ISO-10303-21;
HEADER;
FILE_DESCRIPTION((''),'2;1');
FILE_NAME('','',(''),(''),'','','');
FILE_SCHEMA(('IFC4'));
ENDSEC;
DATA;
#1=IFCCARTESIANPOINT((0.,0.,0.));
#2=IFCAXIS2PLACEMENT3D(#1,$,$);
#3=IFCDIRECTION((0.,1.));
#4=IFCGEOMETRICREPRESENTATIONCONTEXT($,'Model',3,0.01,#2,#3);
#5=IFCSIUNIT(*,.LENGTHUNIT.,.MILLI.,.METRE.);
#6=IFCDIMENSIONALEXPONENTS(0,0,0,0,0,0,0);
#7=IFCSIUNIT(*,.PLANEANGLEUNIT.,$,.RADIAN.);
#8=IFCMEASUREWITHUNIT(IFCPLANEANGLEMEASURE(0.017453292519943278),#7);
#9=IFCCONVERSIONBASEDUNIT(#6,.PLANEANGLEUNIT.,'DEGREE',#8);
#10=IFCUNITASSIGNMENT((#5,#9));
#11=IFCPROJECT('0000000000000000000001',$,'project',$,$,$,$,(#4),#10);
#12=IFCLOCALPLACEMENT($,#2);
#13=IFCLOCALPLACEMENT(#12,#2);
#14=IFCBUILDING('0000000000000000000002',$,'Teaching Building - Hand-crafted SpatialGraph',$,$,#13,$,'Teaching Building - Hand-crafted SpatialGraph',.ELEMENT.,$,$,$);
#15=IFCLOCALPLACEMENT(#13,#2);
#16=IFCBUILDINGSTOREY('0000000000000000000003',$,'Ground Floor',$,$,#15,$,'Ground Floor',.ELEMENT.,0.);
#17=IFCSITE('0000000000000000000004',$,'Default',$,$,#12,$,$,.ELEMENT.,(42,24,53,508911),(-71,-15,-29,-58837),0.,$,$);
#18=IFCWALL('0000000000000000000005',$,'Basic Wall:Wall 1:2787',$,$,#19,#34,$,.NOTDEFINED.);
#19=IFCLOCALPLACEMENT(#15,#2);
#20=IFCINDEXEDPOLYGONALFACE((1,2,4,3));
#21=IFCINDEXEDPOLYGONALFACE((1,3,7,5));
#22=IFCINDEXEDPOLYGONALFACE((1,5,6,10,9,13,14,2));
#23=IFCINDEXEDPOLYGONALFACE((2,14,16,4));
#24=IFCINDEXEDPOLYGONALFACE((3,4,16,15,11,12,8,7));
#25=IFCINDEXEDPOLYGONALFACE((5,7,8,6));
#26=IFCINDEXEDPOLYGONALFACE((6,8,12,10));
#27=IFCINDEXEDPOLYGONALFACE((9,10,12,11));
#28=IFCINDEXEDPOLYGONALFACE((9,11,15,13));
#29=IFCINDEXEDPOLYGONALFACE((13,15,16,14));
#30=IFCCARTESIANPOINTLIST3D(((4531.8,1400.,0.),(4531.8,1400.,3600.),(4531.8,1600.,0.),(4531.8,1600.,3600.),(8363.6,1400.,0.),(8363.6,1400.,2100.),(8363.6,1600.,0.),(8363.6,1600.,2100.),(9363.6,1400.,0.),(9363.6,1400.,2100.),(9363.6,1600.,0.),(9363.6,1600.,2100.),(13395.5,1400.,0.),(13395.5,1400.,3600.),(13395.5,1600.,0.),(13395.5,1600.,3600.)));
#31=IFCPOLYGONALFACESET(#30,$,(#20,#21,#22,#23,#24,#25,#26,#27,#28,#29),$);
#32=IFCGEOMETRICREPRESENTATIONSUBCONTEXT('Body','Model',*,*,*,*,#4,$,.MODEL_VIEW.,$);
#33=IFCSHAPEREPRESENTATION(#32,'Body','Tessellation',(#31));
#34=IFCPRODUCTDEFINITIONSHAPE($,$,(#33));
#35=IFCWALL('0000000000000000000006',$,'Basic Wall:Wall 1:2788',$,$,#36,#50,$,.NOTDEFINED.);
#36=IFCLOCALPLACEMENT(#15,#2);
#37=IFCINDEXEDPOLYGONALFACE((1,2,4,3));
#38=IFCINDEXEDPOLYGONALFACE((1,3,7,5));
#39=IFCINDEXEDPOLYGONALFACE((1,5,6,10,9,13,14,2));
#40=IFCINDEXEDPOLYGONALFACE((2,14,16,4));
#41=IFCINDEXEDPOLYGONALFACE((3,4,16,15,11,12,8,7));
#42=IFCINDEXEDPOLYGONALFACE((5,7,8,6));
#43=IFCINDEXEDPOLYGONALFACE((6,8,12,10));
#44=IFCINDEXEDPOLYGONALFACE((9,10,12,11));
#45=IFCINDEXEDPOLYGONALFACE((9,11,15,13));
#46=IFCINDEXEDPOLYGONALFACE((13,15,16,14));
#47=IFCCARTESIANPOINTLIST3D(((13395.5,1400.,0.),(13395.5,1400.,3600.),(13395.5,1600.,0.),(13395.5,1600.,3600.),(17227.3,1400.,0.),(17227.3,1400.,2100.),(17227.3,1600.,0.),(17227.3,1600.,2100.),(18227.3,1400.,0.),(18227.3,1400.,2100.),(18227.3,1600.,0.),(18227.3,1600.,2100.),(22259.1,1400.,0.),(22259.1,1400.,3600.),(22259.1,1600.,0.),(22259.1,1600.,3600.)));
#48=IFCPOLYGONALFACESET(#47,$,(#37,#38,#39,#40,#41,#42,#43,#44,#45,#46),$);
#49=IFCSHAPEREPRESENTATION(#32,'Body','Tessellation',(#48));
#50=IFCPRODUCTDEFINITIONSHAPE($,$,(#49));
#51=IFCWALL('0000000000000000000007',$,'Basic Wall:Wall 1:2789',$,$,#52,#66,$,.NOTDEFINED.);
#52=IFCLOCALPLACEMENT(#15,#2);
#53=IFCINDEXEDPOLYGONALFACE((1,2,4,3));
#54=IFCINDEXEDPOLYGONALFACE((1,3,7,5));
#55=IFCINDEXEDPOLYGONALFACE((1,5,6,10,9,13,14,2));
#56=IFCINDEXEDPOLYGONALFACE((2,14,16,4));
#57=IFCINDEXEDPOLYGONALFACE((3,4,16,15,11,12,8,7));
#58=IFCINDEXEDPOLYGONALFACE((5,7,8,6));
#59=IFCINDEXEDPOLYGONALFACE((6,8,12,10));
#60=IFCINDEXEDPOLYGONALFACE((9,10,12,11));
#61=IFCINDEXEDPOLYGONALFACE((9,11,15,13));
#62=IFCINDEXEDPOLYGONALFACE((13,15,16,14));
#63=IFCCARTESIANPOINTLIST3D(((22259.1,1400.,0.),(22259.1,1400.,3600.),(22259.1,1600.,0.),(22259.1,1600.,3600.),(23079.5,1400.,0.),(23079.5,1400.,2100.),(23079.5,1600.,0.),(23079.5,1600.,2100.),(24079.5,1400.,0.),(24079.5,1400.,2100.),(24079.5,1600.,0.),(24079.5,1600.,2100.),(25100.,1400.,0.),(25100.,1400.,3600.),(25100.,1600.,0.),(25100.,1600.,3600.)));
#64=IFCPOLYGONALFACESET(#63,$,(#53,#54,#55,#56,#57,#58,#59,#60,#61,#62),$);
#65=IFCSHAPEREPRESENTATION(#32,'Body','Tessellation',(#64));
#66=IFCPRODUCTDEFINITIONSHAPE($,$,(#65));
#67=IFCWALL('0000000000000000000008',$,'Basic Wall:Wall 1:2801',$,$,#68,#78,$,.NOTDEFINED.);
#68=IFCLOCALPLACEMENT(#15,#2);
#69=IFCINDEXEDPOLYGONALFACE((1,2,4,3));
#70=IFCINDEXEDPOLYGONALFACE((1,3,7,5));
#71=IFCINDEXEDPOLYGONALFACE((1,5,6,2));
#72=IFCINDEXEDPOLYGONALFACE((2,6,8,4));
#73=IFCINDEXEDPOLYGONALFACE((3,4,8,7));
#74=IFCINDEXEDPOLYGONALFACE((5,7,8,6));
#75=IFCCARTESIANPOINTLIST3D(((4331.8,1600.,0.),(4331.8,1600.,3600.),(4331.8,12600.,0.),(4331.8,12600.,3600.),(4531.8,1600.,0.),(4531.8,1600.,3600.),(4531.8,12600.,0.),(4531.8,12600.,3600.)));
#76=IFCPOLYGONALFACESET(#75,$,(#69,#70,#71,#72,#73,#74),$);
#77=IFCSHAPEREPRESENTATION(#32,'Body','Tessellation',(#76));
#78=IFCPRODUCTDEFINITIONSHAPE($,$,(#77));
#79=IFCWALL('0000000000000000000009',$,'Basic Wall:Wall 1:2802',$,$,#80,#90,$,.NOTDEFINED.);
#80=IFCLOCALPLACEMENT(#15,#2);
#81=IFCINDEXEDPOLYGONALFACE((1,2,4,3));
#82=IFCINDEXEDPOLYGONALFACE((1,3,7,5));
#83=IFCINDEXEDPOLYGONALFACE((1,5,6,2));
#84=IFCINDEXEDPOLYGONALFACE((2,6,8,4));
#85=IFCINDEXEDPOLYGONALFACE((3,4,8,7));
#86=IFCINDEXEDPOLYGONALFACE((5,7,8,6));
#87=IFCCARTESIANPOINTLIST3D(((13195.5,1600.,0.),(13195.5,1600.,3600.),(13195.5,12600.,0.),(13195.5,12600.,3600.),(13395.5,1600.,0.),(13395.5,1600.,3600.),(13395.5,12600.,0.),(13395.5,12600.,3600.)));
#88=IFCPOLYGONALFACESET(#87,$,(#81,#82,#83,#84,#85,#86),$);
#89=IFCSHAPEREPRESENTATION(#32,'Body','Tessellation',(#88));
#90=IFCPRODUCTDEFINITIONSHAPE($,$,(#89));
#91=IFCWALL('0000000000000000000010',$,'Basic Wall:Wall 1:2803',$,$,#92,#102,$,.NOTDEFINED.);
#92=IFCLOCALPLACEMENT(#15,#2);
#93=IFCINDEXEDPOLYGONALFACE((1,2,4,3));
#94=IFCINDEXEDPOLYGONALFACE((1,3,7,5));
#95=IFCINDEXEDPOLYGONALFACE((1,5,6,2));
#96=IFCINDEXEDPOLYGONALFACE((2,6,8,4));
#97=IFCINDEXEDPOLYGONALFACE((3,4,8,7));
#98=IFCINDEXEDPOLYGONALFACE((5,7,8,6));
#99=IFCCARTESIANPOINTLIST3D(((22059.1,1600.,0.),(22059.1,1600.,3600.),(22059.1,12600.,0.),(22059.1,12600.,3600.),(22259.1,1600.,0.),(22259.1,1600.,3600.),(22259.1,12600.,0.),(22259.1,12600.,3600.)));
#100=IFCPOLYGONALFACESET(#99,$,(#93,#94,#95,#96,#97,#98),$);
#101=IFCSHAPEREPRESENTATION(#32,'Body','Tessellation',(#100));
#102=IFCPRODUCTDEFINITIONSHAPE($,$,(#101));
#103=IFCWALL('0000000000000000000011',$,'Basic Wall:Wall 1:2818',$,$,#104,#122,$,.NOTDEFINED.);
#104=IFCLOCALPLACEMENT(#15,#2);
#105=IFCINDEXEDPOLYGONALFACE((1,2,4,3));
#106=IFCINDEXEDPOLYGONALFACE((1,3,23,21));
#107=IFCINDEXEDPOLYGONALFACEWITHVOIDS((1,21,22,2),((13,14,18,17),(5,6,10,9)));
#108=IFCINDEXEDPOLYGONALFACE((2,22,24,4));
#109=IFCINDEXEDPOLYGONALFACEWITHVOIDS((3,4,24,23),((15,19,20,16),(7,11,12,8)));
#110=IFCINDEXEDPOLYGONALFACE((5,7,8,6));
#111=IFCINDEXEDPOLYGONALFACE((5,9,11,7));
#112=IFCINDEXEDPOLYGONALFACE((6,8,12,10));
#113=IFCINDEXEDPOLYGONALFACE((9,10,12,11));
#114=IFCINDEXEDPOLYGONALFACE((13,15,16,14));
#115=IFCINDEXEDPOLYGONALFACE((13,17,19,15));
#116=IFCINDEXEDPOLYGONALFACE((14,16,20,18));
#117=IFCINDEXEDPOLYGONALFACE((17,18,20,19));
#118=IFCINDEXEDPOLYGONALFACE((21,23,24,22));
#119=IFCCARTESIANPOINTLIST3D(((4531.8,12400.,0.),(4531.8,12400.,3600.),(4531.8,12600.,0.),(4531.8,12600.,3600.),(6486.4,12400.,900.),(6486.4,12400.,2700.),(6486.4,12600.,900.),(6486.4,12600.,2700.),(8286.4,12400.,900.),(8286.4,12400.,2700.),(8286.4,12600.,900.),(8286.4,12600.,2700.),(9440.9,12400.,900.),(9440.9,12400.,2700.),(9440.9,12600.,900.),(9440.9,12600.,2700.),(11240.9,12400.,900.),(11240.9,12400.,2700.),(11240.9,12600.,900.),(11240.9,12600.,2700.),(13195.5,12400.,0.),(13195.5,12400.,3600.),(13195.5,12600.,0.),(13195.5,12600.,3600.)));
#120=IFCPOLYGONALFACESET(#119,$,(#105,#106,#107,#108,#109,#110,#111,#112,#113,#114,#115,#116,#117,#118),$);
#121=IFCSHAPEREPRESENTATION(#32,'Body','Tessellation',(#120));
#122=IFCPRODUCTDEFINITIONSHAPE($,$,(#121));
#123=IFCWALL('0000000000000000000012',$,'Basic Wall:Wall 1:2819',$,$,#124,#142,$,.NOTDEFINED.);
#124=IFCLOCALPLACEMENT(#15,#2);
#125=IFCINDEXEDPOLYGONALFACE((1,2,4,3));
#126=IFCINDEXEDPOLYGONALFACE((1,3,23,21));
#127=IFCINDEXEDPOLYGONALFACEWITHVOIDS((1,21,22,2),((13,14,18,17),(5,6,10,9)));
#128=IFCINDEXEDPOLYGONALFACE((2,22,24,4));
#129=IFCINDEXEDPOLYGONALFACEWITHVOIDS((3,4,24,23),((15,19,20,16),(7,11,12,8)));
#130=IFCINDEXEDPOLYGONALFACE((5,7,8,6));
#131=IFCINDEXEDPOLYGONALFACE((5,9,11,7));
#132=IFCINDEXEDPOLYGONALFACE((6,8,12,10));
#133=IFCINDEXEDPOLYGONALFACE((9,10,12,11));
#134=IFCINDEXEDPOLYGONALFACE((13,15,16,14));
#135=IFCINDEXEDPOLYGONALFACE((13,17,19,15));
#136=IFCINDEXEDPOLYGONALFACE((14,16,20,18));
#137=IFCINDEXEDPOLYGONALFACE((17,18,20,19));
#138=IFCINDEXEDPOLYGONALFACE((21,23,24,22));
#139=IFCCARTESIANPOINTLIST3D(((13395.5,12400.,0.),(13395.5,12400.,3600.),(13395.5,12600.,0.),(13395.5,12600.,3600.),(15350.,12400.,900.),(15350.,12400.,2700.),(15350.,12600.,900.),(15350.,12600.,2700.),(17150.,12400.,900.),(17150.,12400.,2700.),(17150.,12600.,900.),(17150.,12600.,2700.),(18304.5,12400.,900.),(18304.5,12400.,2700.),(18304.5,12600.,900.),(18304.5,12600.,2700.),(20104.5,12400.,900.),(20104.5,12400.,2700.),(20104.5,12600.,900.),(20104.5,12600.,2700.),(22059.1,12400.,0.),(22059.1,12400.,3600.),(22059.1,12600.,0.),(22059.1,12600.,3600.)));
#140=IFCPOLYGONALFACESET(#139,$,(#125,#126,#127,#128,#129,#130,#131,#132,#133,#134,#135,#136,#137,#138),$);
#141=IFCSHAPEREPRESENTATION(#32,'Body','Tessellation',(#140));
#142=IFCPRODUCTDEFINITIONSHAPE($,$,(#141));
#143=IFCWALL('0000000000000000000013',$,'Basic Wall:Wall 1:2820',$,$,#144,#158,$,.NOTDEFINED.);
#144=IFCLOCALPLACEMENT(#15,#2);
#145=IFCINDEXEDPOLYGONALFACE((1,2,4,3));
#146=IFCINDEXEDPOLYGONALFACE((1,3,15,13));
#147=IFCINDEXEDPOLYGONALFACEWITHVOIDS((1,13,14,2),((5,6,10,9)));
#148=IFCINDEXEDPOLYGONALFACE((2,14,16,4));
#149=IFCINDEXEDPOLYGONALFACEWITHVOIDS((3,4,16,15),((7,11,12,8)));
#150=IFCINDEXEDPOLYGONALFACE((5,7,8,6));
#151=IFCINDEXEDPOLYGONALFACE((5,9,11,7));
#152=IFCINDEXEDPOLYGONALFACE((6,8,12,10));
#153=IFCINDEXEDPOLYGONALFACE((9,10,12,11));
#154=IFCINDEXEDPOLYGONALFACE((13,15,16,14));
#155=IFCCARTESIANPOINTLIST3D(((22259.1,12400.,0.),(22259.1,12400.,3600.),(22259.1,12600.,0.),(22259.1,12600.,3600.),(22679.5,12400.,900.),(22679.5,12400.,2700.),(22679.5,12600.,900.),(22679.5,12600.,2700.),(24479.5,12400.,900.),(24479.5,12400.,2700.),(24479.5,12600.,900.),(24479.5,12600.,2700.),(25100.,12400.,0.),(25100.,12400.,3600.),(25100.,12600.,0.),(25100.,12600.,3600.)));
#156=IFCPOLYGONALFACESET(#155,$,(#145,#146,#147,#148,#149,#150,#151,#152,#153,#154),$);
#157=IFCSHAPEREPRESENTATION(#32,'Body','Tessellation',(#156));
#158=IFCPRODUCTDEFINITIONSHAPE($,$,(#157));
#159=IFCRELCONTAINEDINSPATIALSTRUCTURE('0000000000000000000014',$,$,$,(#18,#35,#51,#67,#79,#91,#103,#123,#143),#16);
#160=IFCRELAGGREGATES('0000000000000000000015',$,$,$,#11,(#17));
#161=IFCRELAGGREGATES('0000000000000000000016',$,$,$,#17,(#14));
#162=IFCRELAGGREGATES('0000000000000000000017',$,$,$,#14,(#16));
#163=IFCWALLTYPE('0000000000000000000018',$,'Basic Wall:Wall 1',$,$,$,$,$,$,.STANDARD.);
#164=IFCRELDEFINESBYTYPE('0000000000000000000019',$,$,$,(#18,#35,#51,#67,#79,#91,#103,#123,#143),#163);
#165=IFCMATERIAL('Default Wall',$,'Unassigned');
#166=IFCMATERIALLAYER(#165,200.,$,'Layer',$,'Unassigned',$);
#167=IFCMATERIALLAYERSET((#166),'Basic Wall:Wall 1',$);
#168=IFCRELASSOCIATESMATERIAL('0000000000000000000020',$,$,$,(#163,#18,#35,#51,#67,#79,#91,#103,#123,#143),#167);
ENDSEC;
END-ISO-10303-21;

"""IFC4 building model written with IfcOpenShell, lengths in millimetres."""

from ifc_helpers import new_model, entity, si_unit, converted_unit, direction, frame, frame_2d, origin, origin_2d_with_axis, place, context, subcontext, project, spatial, rectangle, extrude, material, layer, layer_set, layer_usage, type_object, element, save


model = new_model("IFC4")

# Units and contexts
model_context = context("Model", 3, precision=0.01, world=origin(), true_north=direction((0.0, 1.0)))
body_context = subcontext(model_context, "Body", "Model", "MODEL_VIEW")
ifc_project = project(units=[si_unit("LENGTHUNIT", "METRE", prefix="MILLI"), converted_unit("PLANEANGLEUNIT", "DEGREE", entity("IfcPlaneAngleMeasure", 0.017453292519943278), si_unit("PLANEANGLEUNIT", "RADIAN"), dimensions=[0, 0, 0, 0, 0, 0, 0])], contexts=[model_context])

# Site, building, storey
site_placement = place(None, origin())
site = spatial("IfcSite", under=ifc_project, at=site_placement, Name="Default", CompositionType="ELEMENT", RefLatitude=(42, 24, 53, 508911), RefLongitude=(-71, -15, -29, -58837), RefElevation=0.0)
building_placement = place(site_placement, origin())
building = spatial("IfcBuilding", under=site, at=building_placement, Name="Teaching Building - Hand-crafted SpatialGraph", LongName="Teaching Building - Hand-crafted SpatialGraph", CompositionType="ELEMENT")
storey_placement = place(building_placement, origin())
storey = spatial("IfcBuildingStorey", under=building, at=storey_placement, Name="Ground Floor", LongName="Ground Floor", CompositionType="ELEMENT", Elevation=0.0)

# Walls, openings
ifc_material = material(Name="Default Wall", Category="Unassigned")
ifc_layer = layer(ifc_material, 200.0, Name="Layer", Category="Unassigned")
ifc_layer_set = layer_set([ifc_layer], Name="Basic Wall:Wall 1")
ifc_layer_usage_1 = layer_usage(ifc_layer_set, "AXIS2", "NEGATIVE", 100.0)
wall_type = type_object("IfcWallType", Name="Basic Wall:Wall 1", PredefinedType="STANDARD", material=ifc_layer_set)
wall_1_placement = place(storey_placement, frame((4531.8, 1500.0, 0.0)))
wall_1 = element("IfcWall", 1, at=wall_1_placement, inside=storey, type_object=wall_type, material=ifc_layer_usage_1, Name="Basic Wall:Wall 1:2787", PredefinedType="NOTDEFINED", context=body_context, shape_type="SweptSolid", body=[
    extrude(rectangle(XDim=8863.6, YDim=200.0, at=frame_2d((4431.8, 0.0), x_axis=(-1.0, 0.0))), origin(), (0.0, 0.0, 1.0), 3600.0),
])
opening_1_placement = place(wall_1_placement, origin())
element("IfcOpeningElement", 2, at=opening_1_placement, cuts=wall_1, PredefinedType="OPENING", context=body_context, shape_type="SweptSolid", body=[
    extrude(rectangle(XDim=2100.0, YDim=1000.0, at=origin_2d_with_axis()), frame((4331.8, -100.0, 1050.0), z_axis=(0.0, 1.0, 0.0), x_axis=(0.0, 0.0, -1.0)), (0.0, 0.0, 1.0), 200.0),
])
ifc_layer_usage_2 = layer_usage(ifc_layer_set, "AXIS2", "NEGATIVE", 100.0)
wall_2_placement = place(storey_placement, frame((13395.5, 1500.0, 0.0)))
wall_2 = element("IfcWall", 3, at=wall_2_placement, inside=storey, type_object=wall_type, material=ifc_layer_usage_2, Name="Basic Wall:Wall 1:2788", PredefinedType="NOTDEFINED", context=body_context, shape_type="SweptSolid", body=[
    extrude(rectangle(XDim=8863.6, YDim=200.0, at=frame_2d((4431.8, 0.0), x_axis=(1.0, 0.0))), origin(), (0.0, 0.0, 1.0), 3600.0),
])
opening_2_placement = place(wall_2_placement, origin())
element("IfcOpeningElement", 4, at=opening_2_placement, cuts=wall_2, PredefinedType="OPENING", context=body_context, shape_type="SweptSolid", body=[
    extrude(rectangle(XDim=2100.0, YDim=1000.0, at=frame_2d((0.0, 0.0), x_axis=(1.0, 0.0))), frame((4331.8, -100.0, 1050.0), z_axis=(0.0, 1.0, 0.0), x_axis=(0.0, 0.0, -1.0)), (0.0, 0.0, 1.0), 200.0),
])
ifc_layer_usage_3 = layer_usage(ifc_layer_set, "AXIS2", "NEGATIVE", 100.0)
wall_3_placement = place(storey_placement, frame((22259.1, 1500.0, 0.0)))
wall_3 = element("IfcWall", 5, at=wall_3_placement, inside=storey, type_object=wall_type, material=ifc_layer_usage_3, Name="Basic Wall:Wall 1:2789", PredefinedType="NOTDEFINED", context=body_context, shape_type="SweptSolid", body=[
    extrude(rectangle(XDim=2840.9, YDim=200.0, at=frame_2d((1420.5, 0.0), x_axis=(-1.0, 0.0))), origin(), (0.0, 0.0, 1.0), 3600.0),
])
opening_3_placement = place(wall_3_placement, origin())
element("IfcOpeningElement", 6, at=opening_3_placement, cuts=wall_3, PredefinedType="OPENING", context=body_context, shape_type="SweptSolid", body=[
    extrude(rectangle(XDim=2100.0, YDim=1000.0, at=frame_2d((0.0, 0.0), x_axis=(1.0, 0.0))), frame((1320.5, -100.0, 1050.0), z_axis=(0.0, 1.0, 0.0), x_axis=(0.0, 0.0, -1.0)), (0.0, 0.0, 1.0), 200.0),
])

# Walls
ifc_layer_usage_4 = layer_usage(ifc_layer_set, "AXIS2", "NEGATIVE", 100.0)
wall_4_placement = place(storey_placement, frame((4431.8, 1600.0, 0.0), z_axis=(0.0, 0.0, 1.0), x_axis=(0.0, 1.0, 0.0)))
element("IfcWall", 7, at=wall_4_placement, inside=storey, type_object=wall_type, material=ifc_layer_usage_4, Name="Basic Wall:Wall 1:2801", PredefinedType="NOTDEFINED", context=body_context, shape_type="SweptSolid", body=[
    extrude(rectangle(XDim=11000.0, YDim=200.0, at=frame_2d((5500.0, 0.0), x_axis=(-1.0, 0.0))), origin(), (0.0, 0.0, 1.0), 3600.0),
])
ifc_layer_usage_5 = layer_usage(ifc_layer_set, "AXIS2", "NEGATIVE", 100.0)
wall_5_placement = place(storey_placement, frame((13295.5, 1600.0, 0.0), z_axis=(0.0, 0.0, 1.0), x_axis=(0.0, 1.0, 0.0)))
element("IfcWall", 8, at=wall_5_placement, inside=storey, type_object=wall_type, material=ifc_layer_usage_5, Name="Basic Wall:Wall 1:2802", PredefinedType="NOTDEFINED", context=body_context, shape_type="SweptSolid", body=[
    extrude(rectangle(XDim=11000.0, YDim=200.0, at=frame_2d((5500.0, 0.0), x_axis=(-1.0, 0.0))), origin(), (0.0, 0.0, 1.0), 3600.0),
])
ifc_layer_usage_6 = layer_usage(ifc_layer_set, "AXIS2", "NEGATIVE", 100.0)
wall_6_placement = place(storey_placement, frame((22159.1, 1600.0, 0.0), z_axis=(0.0, 0.0, 1.0), x_axis=(0.0, 1.0, 0.0)))
element("IfcWall", 9, at=wall_6_placement, inside=storey, type_object=wall_type, material=ifc_layer_usage_6, Name="Basic Wall:Wall 1:2803", PredefinedType="NOTDEFINED", context=body_context, shape_type="SweptSolid", body=[
    extrude(rectangle(XDim=11000.0, YDim=200.0, at=frame_2d((5500.0, 0.0), x_axis=(-1.0, 0.0))), origin(), (0.0, 0.0, 1.0), 3600.0),
])

# Walls, openings
ifc_layer_usage_7 = layer_usage(ifc_layer_set, "AXIS2", "NEGATIVE", 100.0)
wall_7_placement = place(storey_placement, frame((4531.8, 12500.0, 0.0)))
wall_7 = element("IfcWall", 10, at=wall_7_placement, inside=storey, type_object=wall_type, material=ifc_layer_usage_7, Name="Basic Wall:Wall 1:2818", PredefinedType="NOTDEFINED", context=body_context, shape_type="SweptSolid", body=[
    extrude(rectangle(XDim=8663.6, YDim=200.0, at=frame_2d((4331.8, 0.0), x_axis=(-1.0, 0.0))), origin(), (0.0, 0.0, 1.0), 3600.0),
])
opening_4_placement = place(wall_7_placement, origin())
element("IfcOpeningElement", 11, at=opening_4_placement, cuts=wall_7, PredefinedType="OPENING", context=body_context, shape_type="SweptSolid", body=[
    extrude(rectangle(XDim=1800.0, YDim=1800.0, at=frame_2d((0.0, 0.0), x_axis=(1.0, 0.0))), frame((2854.5, -100.0, 1800.0), z_axis=(0.0, 1.0, 0.0), x_axis=(0.0, 0.0, -1.0)), (0.0, 0.0, 1.0), 200.0),
])
opening_5_placement = place(wall_7_placement, origin())
element("IfcOpeningElement", 12, at=opening_5_placement, cuts=wall_7, PredefinedType="OPENING", context=body_context, shape_type="SweptSolid", body=[
    extrude(rectangle(XDim=1800.0, YDim=1800.0, at=frame_2d((0.0, 0.0), x_axis=(1.0, 0.0))), frame((5809.1, -100.0, 1800.0), z_axis=(0.0, 1.0, 0.0), x_axis=(0.0, 0.0, -1.0)), (0.0, 0.0, 1.0), 200.0),
])
ifc_layer_usage_8 = layer_usage(ifc_layer_set, "AXIS2", "NEGATIVE", 100.0)
wall_8_placement = place(storey_placement, frame((13395.5, 12500.0, 0.0)))
wall_8 = element("IfcWall", 13, at=wall_8_placement, inside=storey, type_object=wall_type, material=ifc_layer_usage_8, Name="Basic Wall:Wall 1:2819", PredefinedType="NOTDEFINED", context=body_context, shape_type="SweptSolid", body=[
    extrude(rectangle(XDim=8663.6, YDim=200.0, at=frame_2d((4331.8, 0.0), x_axis=(-1.0, 0.0))), origin(), (0.0, 0.0, 1.0), 3600.0),
])
opening_6_placement = place(wall_8_placement, origin())
element("IfcOpeningElement", 14, at=opening_6_placement, cuts=wall_8, PredefinedType="OPENING", context=body_context, shape_type="SweptSolid", body=[
    extrude(rectangle(XDim=1800.0, YDim=1800.0, at=frame_2d((0.0, 0.0), x_axis=(1.0, 0.0))), frame((2854.5, -100.0, 1800.0), z_axis=(0.0, 1.0, 0.0), x_axis=(0.0, 0.0, -1.0)), (0.0, 0.0, 1.0), 200.0),
])
opening_7_placement = place(wall_8_placement, origin())
element("IfcOpeningElement", 15, at=opening_7_placement, cuts=wall_8, PredefinedType="OPENING", context=body_context, shape_type="SweptSolid", body=[
    extrude(rectangle(XDim=1800.0, YDim=1800.0, at=origin_2d_with_axis()), frame((5809.1, -100.0, 1800.0), z_axis=(0.0, 1.0, 0.0), x_axis=(0.0, 0.0, -1.0)), (0.0, 0.0, 1.0), 200.0),
])

# Wall, opening
ifc_layer_usage_9 = layer_usage(ifc_layer_set, "AXIS2", "NEGATIVE", 100.0)
wall_9_placement = place(storey_placement, frame((22259.1, 12500.0, 0.0)))
wall_9 = element("IfcWall", 16, at=wall_9_placement, inside=storey, type_object=wall_type, material=ifc_layer_usage_9, Name="Basic Wall:Wall 1:2820", PredefinedType="NOTDEFINED", context=body_context, shape_type="SweptSolid", body=[
    extrude(rectangle(XDim=2840.9, YDim=200.0, at=frame_2d((1420.5, 0.0), x_axis=(-1.0, 0.0))), origin(), (0.0, 0.0, 1.0), 3600.0),
])
opening_8_placement = place(wall_9_placement, origin())
element("IfcOpeningElement", 17, at=opening_8_placement, cuts=wall_9, PredefinedType="OPENING", context=body_context, shape_type="SweptSolid", body=[
    extrude(rectangle(XDim=1800.0, YDim=1800.0, at=frame_2d((0.0, 0.0), x_axis=(1.0, 0.0))), frame((1320.5, -100.0, 1800.0), z_axis=(0.0, 1.0, 0.0), x_axis=(0.0, 0.0, -1.0)), (0.0, 0.0, 1.0), 200.0),
])

save(model, "model.ifc")
